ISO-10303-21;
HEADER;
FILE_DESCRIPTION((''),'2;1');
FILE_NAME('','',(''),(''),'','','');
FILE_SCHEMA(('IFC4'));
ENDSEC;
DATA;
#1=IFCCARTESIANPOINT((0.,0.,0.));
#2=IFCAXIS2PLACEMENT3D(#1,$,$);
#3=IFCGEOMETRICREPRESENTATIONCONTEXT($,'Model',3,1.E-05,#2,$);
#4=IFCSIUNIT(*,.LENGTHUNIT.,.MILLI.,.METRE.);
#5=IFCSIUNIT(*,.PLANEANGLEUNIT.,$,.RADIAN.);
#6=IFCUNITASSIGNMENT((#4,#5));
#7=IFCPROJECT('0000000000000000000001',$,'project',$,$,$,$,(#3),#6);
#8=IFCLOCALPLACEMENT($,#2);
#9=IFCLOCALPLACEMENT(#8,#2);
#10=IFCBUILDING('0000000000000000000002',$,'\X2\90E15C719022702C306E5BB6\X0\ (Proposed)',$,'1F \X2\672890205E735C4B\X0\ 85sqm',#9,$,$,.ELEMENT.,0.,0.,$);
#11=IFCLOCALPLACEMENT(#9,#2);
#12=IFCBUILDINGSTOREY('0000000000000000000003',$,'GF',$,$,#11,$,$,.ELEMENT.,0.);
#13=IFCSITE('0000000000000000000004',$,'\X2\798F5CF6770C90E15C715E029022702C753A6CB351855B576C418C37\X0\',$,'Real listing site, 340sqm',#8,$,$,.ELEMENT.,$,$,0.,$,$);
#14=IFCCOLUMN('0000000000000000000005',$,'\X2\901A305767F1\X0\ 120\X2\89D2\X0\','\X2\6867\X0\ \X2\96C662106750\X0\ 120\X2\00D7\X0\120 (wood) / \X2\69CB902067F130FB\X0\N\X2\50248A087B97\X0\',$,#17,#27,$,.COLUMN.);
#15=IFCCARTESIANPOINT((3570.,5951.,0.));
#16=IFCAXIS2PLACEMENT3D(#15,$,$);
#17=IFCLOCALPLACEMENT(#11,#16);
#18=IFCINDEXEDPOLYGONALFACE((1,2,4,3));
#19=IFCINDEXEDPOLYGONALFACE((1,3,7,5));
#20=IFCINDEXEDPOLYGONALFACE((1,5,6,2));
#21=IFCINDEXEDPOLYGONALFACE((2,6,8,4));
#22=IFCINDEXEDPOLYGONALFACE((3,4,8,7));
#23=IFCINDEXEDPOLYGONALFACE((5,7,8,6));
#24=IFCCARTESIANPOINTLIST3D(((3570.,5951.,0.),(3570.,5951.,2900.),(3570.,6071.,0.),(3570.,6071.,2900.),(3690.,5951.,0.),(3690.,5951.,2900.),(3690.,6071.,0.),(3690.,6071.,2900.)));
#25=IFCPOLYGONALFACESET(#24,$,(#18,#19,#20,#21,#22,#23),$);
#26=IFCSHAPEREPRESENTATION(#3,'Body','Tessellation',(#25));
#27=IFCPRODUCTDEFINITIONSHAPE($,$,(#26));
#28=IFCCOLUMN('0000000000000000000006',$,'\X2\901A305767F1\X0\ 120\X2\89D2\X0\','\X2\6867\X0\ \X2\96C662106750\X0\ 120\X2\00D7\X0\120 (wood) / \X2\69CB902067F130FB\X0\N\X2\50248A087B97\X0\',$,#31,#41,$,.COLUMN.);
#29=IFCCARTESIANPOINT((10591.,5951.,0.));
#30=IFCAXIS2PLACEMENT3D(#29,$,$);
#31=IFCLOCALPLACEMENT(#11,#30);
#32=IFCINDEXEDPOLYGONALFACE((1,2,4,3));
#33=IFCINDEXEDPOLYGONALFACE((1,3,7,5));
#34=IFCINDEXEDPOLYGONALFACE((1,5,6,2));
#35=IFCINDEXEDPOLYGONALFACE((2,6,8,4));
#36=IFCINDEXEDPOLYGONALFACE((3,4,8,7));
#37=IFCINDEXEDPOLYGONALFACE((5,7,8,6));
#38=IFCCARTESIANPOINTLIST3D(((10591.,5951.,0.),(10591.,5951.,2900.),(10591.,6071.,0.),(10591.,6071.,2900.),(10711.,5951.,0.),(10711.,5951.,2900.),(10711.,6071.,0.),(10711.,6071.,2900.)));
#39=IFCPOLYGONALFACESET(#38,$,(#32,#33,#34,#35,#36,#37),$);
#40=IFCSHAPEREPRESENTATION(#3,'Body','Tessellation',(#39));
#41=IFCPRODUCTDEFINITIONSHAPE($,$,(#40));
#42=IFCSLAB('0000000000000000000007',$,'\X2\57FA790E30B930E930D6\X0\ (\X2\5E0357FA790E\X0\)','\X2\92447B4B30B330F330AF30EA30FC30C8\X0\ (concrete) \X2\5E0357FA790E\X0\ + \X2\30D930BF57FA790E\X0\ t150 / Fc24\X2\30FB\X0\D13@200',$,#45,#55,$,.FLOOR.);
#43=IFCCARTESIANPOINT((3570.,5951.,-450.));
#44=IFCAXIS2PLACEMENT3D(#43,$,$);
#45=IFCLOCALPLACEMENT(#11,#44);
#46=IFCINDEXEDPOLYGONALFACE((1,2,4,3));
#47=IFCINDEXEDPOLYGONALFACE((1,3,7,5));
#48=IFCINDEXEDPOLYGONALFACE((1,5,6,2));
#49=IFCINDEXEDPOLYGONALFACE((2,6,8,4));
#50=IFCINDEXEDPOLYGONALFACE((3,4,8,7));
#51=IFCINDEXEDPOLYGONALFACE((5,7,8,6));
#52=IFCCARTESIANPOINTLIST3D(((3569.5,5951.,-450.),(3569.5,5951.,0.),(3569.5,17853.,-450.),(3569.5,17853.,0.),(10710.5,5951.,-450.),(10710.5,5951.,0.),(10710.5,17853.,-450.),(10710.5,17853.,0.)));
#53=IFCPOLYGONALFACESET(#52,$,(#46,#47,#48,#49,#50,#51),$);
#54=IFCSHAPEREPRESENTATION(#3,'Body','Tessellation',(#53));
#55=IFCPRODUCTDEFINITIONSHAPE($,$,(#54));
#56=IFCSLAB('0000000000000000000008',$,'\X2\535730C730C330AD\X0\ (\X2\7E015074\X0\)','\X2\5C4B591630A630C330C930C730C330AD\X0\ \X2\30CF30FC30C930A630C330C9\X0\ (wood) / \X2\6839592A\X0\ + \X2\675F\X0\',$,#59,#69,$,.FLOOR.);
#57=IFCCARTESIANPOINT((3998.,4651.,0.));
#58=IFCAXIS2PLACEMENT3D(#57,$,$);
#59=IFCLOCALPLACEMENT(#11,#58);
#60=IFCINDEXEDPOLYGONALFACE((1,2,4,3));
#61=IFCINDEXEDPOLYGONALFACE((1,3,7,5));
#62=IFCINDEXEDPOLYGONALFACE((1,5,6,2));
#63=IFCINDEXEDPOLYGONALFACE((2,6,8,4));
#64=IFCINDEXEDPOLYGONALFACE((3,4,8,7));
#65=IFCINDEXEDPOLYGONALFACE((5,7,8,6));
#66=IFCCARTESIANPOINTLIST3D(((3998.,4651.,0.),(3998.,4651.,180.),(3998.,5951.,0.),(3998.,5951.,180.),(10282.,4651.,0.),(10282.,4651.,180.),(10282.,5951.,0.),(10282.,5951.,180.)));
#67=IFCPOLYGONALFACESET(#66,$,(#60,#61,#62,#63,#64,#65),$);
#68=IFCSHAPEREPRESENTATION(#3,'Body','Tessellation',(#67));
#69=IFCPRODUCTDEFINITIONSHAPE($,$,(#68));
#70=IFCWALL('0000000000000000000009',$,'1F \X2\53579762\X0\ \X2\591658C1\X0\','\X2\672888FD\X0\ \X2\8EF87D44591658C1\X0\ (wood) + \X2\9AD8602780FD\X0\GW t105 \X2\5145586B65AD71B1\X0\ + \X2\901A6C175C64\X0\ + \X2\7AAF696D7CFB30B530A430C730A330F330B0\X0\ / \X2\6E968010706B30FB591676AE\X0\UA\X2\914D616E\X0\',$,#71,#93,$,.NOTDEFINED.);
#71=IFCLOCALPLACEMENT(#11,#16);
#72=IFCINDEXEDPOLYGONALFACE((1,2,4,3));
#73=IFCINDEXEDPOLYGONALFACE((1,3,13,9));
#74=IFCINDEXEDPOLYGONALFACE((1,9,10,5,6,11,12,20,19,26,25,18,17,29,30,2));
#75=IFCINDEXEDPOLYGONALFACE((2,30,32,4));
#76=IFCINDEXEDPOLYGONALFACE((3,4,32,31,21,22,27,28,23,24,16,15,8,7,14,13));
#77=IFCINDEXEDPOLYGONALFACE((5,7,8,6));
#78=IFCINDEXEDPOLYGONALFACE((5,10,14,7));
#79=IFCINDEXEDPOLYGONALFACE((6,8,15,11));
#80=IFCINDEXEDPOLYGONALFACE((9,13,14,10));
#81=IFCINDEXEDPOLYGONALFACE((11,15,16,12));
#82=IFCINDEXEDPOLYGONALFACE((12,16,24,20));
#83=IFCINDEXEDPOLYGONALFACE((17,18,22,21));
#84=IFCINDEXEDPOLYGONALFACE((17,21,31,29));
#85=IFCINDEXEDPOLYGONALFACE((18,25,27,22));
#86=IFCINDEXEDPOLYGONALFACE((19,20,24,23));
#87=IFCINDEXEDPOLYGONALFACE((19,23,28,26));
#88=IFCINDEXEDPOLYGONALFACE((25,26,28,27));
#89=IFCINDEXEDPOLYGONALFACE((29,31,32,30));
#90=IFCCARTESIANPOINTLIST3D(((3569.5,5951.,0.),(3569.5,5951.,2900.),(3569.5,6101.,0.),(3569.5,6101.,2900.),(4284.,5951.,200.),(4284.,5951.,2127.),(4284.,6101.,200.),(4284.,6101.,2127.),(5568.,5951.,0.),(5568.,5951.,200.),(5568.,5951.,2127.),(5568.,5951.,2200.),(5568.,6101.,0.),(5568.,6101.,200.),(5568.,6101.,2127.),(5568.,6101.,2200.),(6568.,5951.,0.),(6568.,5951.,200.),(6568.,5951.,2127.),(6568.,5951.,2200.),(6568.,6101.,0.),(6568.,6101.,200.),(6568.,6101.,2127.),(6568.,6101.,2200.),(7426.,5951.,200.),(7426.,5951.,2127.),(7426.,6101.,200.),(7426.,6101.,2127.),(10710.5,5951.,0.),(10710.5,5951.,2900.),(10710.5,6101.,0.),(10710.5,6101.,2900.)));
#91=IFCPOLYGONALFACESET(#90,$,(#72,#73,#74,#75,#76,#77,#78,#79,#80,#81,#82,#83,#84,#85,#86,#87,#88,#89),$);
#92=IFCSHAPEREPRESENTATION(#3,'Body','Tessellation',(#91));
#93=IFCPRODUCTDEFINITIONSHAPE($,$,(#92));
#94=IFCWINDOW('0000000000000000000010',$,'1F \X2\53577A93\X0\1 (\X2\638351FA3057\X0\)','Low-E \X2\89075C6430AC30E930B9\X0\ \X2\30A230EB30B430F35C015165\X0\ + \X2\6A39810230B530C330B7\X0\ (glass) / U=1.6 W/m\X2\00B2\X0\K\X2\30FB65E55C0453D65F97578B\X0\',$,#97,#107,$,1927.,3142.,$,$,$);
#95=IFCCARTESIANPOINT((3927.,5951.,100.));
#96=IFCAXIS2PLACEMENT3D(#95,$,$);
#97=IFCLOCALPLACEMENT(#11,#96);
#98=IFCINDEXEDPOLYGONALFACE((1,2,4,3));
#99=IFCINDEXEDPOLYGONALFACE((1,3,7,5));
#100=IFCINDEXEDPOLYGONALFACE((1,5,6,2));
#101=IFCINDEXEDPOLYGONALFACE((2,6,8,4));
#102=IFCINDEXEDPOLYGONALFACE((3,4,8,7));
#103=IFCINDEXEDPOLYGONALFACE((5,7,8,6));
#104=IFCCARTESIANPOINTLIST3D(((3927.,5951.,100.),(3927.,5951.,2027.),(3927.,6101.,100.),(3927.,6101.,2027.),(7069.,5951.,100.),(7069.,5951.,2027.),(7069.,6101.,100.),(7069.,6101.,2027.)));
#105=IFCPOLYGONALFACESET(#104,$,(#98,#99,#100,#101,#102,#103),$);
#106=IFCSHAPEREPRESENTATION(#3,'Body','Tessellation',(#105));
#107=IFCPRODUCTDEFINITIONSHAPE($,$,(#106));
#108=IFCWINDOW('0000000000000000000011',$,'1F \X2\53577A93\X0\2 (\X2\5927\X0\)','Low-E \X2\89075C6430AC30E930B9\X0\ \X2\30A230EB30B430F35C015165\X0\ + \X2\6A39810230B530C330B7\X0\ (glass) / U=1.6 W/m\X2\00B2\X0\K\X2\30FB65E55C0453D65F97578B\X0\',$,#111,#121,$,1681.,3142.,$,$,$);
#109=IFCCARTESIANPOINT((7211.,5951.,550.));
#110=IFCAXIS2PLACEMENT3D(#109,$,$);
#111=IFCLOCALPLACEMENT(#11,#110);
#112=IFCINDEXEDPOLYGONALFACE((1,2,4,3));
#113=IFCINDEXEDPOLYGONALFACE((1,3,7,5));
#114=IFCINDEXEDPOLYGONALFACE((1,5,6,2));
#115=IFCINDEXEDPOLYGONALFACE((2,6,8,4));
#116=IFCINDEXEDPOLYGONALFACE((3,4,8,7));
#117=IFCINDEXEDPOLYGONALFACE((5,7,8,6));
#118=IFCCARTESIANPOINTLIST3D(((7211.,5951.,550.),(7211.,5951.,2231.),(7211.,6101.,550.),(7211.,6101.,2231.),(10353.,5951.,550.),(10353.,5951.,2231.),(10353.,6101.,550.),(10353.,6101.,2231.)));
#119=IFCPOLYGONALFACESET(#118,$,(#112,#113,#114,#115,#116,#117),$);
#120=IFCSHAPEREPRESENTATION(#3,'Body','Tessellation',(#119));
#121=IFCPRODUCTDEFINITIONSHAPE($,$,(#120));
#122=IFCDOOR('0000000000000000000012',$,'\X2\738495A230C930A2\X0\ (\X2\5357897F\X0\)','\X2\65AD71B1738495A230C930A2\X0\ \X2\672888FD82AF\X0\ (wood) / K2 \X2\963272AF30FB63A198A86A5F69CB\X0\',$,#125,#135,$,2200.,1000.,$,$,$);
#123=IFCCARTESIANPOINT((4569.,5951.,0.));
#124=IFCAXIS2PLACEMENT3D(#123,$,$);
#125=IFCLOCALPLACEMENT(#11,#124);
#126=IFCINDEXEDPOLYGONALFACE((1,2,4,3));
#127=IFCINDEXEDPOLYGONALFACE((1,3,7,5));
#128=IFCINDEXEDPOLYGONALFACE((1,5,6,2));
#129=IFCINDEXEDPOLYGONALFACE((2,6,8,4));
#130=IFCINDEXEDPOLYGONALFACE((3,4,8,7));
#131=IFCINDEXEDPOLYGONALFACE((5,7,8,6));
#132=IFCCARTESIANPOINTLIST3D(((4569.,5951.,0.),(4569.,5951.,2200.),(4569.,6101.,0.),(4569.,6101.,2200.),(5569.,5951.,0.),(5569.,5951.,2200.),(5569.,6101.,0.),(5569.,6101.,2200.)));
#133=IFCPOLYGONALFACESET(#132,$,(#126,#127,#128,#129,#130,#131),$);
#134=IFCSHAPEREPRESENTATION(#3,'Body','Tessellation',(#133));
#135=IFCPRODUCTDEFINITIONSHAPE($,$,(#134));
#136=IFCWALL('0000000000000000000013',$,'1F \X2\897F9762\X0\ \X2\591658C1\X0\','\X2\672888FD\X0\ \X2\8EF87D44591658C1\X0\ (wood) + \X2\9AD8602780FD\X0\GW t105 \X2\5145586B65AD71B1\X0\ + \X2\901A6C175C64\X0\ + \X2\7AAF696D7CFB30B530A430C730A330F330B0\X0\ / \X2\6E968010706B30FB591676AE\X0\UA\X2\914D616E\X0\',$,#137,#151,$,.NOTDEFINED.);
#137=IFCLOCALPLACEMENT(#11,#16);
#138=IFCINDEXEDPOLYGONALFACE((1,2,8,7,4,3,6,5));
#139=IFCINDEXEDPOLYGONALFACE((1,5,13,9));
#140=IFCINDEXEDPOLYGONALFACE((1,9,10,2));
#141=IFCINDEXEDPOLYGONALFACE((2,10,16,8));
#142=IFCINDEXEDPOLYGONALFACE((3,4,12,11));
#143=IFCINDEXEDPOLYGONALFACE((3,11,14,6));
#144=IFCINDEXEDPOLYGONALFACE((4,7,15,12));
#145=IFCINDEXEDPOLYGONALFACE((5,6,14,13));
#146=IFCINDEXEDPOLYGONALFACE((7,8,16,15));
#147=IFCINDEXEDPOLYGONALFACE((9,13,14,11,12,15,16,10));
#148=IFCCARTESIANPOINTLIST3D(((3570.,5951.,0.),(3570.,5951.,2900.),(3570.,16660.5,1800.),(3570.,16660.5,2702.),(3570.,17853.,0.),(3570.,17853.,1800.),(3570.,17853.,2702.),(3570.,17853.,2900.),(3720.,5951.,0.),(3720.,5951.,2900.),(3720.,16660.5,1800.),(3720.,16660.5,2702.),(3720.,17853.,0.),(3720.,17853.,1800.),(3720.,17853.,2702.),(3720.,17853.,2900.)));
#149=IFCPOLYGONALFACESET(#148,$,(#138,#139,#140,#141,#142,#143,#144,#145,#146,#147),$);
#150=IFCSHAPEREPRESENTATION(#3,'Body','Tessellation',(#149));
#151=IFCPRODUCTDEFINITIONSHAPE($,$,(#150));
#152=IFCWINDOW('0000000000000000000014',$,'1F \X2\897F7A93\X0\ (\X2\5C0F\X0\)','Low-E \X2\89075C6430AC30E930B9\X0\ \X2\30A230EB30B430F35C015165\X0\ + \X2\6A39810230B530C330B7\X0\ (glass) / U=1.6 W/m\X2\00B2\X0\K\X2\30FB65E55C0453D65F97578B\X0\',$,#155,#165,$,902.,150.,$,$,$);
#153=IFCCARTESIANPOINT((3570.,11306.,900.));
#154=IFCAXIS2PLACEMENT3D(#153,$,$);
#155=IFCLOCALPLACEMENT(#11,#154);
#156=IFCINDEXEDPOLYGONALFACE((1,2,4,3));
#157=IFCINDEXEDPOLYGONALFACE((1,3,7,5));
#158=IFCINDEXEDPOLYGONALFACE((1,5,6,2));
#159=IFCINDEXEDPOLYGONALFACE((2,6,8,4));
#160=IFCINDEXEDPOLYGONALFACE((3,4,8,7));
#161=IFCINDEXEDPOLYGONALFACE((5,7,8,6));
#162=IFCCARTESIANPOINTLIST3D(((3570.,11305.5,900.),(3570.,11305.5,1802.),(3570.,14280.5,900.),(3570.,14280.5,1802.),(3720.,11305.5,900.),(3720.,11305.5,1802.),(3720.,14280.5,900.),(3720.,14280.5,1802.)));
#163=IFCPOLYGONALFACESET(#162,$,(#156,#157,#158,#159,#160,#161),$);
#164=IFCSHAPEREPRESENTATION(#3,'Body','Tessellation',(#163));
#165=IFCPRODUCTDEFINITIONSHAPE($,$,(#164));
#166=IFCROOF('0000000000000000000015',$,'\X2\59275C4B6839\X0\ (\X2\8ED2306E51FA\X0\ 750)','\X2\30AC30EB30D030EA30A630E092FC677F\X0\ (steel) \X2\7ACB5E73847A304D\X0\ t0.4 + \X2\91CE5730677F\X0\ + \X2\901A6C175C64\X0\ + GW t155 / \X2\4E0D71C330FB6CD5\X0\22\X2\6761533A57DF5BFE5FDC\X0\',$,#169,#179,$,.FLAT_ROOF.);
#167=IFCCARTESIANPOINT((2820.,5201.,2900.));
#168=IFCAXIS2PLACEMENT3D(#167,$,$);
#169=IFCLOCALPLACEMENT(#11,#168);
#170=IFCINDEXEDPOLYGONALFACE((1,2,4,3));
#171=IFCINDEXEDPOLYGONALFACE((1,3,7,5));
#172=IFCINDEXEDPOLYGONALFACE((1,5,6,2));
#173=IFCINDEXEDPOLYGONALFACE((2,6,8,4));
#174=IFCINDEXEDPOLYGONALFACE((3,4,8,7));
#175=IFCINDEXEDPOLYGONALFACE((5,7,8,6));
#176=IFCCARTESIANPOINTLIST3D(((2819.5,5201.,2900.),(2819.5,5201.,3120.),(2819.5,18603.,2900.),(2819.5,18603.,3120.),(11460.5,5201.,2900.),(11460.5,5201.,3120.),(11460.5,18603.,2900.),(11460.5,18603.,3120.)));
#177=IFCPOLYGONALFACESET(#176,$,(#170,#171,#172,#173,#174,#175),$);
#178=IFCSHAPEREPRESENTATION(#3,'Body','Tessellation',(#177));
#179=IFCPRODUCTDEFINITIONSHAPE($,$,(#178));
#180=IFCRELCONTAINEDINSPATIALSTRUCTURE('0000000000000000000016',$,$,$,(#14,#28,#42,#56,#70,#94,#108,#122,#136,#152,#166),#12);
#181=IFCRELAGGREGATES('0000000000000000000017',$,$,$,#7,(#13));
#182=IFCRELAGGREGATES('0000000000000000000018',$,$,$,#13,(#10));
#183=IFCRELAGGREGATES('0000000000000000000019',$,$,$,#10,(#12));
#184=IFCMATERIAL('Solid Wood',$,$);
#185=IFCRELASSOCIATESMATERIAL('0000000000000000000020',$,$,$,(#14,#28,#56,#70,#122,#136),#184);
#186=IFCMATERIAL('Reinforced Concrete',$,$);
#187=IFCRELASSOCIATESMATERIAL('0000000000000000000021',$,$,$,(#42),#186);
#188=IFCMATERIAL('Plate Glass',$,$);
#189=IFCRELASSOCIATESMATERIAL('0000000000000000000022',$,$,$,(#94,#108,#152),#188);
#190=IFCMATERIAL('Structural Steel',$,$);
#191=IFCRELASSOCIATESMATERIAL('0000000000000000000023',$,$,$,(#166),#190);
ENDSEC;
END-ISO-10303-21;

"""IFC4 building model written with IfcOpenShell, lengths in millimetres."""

from ifc_helpers import new_model, si_unit, frame, frame_2d, origin, place, context, project, spatial, rectangle, extrude, material, element, fill, save


model = new_model("IFC4")

# Units and contexts
model_context = context("Model", 3, precision=1e-05, world=origin())
ifc_project = project(units=[si_unit("LENGTHUNIT", "METRE", prefix="MILLI"), si_unit("PLANEANGLEUNIT", "RADIAN")], contexts=[model_context])

# Site, building, storey
site_placement = place(None, origin())
site = spatial("IfcSite", under=ifc_project, at=site_placement, Name="福島県郡山市逢瀬町河内字汁谷", ObjectType="Real listing site, 340sqm", CompositionType="ELEMENT", RefElevation=0.0)
building_placement = place(site_placement, origin())
building = spatial("IfcBuilding", under=site, at=building_placement, Name="郡山逢瀬の家 (Proposed)", ObjectType="1F 木造平屋 85sqm", CompositionType="ELEMENT", ElevationOfRefHeight=0.0, ElevationOfTerrain=0.0)
storey_placement = place(building_placement, origin())
storey = spatial("IfcBuildingStorey", under=building, at=storey_placement, Name="GF", CompositionType="ELEMENT", Elevation=0.0)

# Columns
ifc_material_1 = material(Name="Solid Wood")
column_1_placement = place(storey_placement, frame((3570.0, 5951.0, 0.0)))
element("IfcColumn", 1, at=column_1_placement, inside=storey, material=ifc_material_1, Name="通し柱 120角", Description="桧 集成材 120×120 (wood) / 構造柱・N値計算", PredefinedType="COLUMN", context=model_context, shape_type="SweptSolid", body=[
    extrude(rectangle(XDim=120.0, YDim=120.0, at=frame_2d((60.0, 60.0))), frame((3570.0, 5951.0, 0.0)), (0.0, 0.0, 1.0), 2900.0),
])
column_2_placement = place(storey_placement, frame((10591.0, 5951.0, 0.0)))
element("IfcColumn", 2, at=column_2_placement, inside=storey, material=ifc_material_1, Name="通し柱 120角", Description="桧 集成材 120×120 (wood) / 構造柱・N値計算", PredefinedType="COLUMN", context=model_context, shape_type="SweptSolid", body=[
    extrude(rectangle(XDim=120.0, YDim=120.0, at=frame_2d((60.0, 60.0))), frame((10591.0, 5951.0, 0.0)), (0.0, 0.0, 1.0), 2900.0),
])

# Slabs
ifc_material_2 = material(Name="Reinforced Concrete")
slab_1_placement = place(storey_placement, frame((3570.0, 5951.0, -450.0)))
element("IfcSlab", 3, at=slab_1_placement, inside=storey, material=ifc_material_2, Name="基礎スラブ (布基礎)", Description="鉄筋コンクリート (concrete) 布基礎 + ベタ基礎 t150 / Fc24・D13@200", PredefinedType="FLOOR", context=model_context, shape_type="SweptSolid", body=[
    extrude(rectangle(XDim=7141.0, YDim=11902.0, at=frame_2d((3570.0, 5951.0))), frame((3570.0, 5951.0, -450.0)), (0.0, 0.0, 1.0), 450.0),
])
slab_2_placement = place(storey_placement, frame((3998.0, 4651.0, 0.0)))
element("IfcSlab", 4, at=slab_2_placement, inside=storey, material=ifc_material_1, Name="南デッキ (縁側)", Description="屋外ウッドデッキ ハードウッド (wood) / 根太 + 束", PredefinedType="FLOOR", context=model_context, shape_type="SweptSolid", body=[
    extrude(rectangle(XDim=6284.0, YDim=1300.0, at=frame_2d((3142.0, 650.0))), frame((3998.0, 4651.0, 0.0)), (0.0, 0.0, 1.0), 180.0),
])

# Wall, openings, windows, door
wall_1_placement = place(storey_placement, frame((3570.0, 5951.0, 0.0)))
wall_1 = element("IfcWall", 5, at=wall_1_placement, inside=storey, material=ifc_material_1, Name="1F 南面 外壁", Description="木製 軸組外壁 (wood) + 高性能GW t105 充填断熱 + 通気層 + 窯業系サイディング / 準耐火・外皮UA配慮", PredefinedType="NOTDEFINED", context=model_context, shape_type="SweptSolid", body=[
    extrude(rectangle(XDim=7141.0, YDim=150.0, at=frame_2d((3570.0, 75.0))), frame((3570.0, 5951.0, 0.0)), (0.0, 0.0, 1.0), 2900.0),
])
opening_1_placement = place(storey_placement, frame((3927.0, 5951.0, 100.0)))
opening_1 = element("IfcOpeningElement", 6, at=opening_1_placement, cuts=wall_1, PredefinedType="NOTDEFINED", context=model_context, shape_type="SweptSolid", body=[
    extrude(rectangle(XDim=3142.0, YDim=150.0, at=frame_2d((1571.0, 75.0))), frame((3927.0, 5951.0, 100.0)), (0.0, 0.0, 1.0), 1927.0),
])
opening_2_placement = place(storey_placement, frame((7211.0, 5951.0, 550.0)))
opening_2 = element("IfcOpeningElement", 7, at=opening_2_placement, cuts=wall_1, PredefinedType="NOTDEFINED", context=model_context, shape_type="SweptSolid", body=[
    extrude(rectangle(XDim=3142.0, YDim=150.0, at=frame_2d((1571.0, 75.0))), frame((7211.0, 5951.0, 550.0)), (0.0, 0.0, 1.0), 1681.0),
])
opening_3_placement = place(storey_placement, frame((4569.0, 5951.0, 0.0)))
opening_3 = element("IfcOpeningElement", 8, at=opening_3_placement, cuts=wall_1, PredefinedType="NOTDEFINED", context=model_context, shape_type="SweptSolid", body=[
    extrude(rectangle(XDim=1000.0, YDim=150.0, at=frame_2d((500.0, 75.0))), frame((4569.0, 5951.0, 0.0)), (0.0, 0.0, 1.0), 2200.0),
])
ifc_material_3 = material(Name="Plate Glass")
window_1_placement = place(storey_placement, frame((3927.0, 5951.0, 100.0)))
window_1 = element("IfcWindow", 9, at=window_1_placement, inside=storey, material=ifc_material_3, Name="1F 南窓1 (掃出し)", Description="Low-E 複層ガラス アルゴン封入 + 樹脂サッシ (glass) / U=1.6 W/m²K・日射取得型", OverallHeight=1927.0, OverallWidth=3142.0, context=model_context, shape_type="SweptSolid", body=[
    extrude(rectangle(XDim=3142.0, YDim=150.0, at=frame_2d((1571.0, 75.0))), frame((3927.0, 5951.0, 100.0)), (0.0, 0.0, 1.0), 1927.0),
])
fill(opening_1, window_1)
window_2_placement = place(storey_placement, frame((7211.0, 5951.0, 550.0)))
window_2 = element("IfcWindow", 10, at=window_2_placement, inside=storey, material=ifc_material_3, Name="1F 南窓2 (大)", Description="Low-E 複層ガラス アルゴン封入 + 樹脂サッシ (glass) / U=1.6 W/m²K・日射取得型", OverallHeight=1681.0, OverallWidth=3142.0, context=model_context, shape_type="SweptSolid", body=[
    extrude(rectangle(XDim=3142.0, YDim=150.0, at=frame_2d((1571.0, 75.0))), frame((7211.0, 5951.0, 550.0)), (0.0, 0.0, 1.0), 1681.0),
])
fill(opening_2, window_2)
door_placement = place(storey_placement, frame((4569.0, 5951.0, 0.0)))
door = element("IfcDoor", 11, at=door_placement, inside=storey, material=ifc_material_1, Name="玄関ドア (南西)", Description="断熱玄関ドア 木製芯 (wood) / K2 防犯・採風機構", OverallHeight=2200.0, OverallWidth=1000.0, context=model_context, shape_type="SweptSolid", body=[
    extrude(rectangle(XDim=1000.0, YDim=150.0, at=frame_2d((500.0, 75.0))), frame((4569.0, 5951.0, 0.0)), (0.0, 0.0, 1.0), 2200.0),
])
fill(opening_3, door)

# Wall, opening, window
wall_2_placement = place(storey_placement, frame((3570.0, 5951.0, 0.0)))
wall_2 = element("IfcWall", 12, at=wall_2_placement, inside=storey, material=ifc_material_1, Name="1F 西面 外壁", Description="木製 軸組外壁 (wood) + 高性能GW t105 充填断熱 + 通気層 + 窯業系サイディング / 準耐火・外皮UA配慮", PredefinedType="NOTDEFINED", context=model_context, shape_type="SweptSolid", body=[
    extrude(rectangle(XDim=150.0, YDim=11902.0, at=frame_2d((75.0, 5951.0))), frame((3570.0, 5951.0, 0.0)), (0.0, 0.0, 1.0), 2900.0),
])
opening_4_placement = place(storey_placement, frame((3570.0, 11306.0, 900.0)))
opening_4 = element("IfcOpeningElement", 13, at=opening_4_placement, cuts=wall_2, PredefinedType="NOTDEFINED", context=model_context, shape_type="SweptSolid", body=[
    extrude(rectangle(XDim=150.0, YDim=2975.0, at=frame_2d((75.0, 1487.0))), frame((3570.0, 11306.0, 900.0)), (0.0, 0.0, 1.0), 902.0),
])
window_3_placement = place(storey_placement, frame((3570.0, 11306.0, 900.0)))
window_3 = element("IfcWindow", 14, at=window_3_placement, inside=storey, material=ifc_material_3, Name="1F 西窓 (小)", Description="Low-E 複層ガラス アルゴン封入 + 樹脂サッシ (glass) / U=1.6 W/m²K・日射取得型", OverallHeight=902.0, OverallWidth=150.0, context=model_context, shape_type="SweptSolid", body=[
    extrude(rectangle(XDim=150.0, YDim=2975.0, at=frame_2d((75.0, 1487.0))), frame((3570.0, 11306.0, 900.0)), (0.0, 0.0, 1.0), 902.0),
])
fill(opening_4, window_3)

# Roof
ifc_material_4 = material(Name="Structural Steel")
roof_placement = place(storey_placement, frame((2820.0, 5201.0, 2900.0)))
element("IfcRoof", 15, at=roof_placement, inside=storey, material=ifc_material_4, Name="大屋根 (軒の出 750)", Description="ガルバリウム鋼板 (steel) 立平葺き t0.4 + 野地板 + 通気層 + GW t155 / 不燃・法22条区域対応", PredefinedType="FLAT_ROOF", context=model_context, shape_type="SweptSolid", body=[
    extrude(rectangle(XDim=8641.0, YDim=13402.0, at=frame_2d((4320.0, 6701.0))), frame((2820.0, 5201.0, 2900.0)), (0.0, 0.0, 1.0), 220.0),
])

save(model, "model.ifc")
